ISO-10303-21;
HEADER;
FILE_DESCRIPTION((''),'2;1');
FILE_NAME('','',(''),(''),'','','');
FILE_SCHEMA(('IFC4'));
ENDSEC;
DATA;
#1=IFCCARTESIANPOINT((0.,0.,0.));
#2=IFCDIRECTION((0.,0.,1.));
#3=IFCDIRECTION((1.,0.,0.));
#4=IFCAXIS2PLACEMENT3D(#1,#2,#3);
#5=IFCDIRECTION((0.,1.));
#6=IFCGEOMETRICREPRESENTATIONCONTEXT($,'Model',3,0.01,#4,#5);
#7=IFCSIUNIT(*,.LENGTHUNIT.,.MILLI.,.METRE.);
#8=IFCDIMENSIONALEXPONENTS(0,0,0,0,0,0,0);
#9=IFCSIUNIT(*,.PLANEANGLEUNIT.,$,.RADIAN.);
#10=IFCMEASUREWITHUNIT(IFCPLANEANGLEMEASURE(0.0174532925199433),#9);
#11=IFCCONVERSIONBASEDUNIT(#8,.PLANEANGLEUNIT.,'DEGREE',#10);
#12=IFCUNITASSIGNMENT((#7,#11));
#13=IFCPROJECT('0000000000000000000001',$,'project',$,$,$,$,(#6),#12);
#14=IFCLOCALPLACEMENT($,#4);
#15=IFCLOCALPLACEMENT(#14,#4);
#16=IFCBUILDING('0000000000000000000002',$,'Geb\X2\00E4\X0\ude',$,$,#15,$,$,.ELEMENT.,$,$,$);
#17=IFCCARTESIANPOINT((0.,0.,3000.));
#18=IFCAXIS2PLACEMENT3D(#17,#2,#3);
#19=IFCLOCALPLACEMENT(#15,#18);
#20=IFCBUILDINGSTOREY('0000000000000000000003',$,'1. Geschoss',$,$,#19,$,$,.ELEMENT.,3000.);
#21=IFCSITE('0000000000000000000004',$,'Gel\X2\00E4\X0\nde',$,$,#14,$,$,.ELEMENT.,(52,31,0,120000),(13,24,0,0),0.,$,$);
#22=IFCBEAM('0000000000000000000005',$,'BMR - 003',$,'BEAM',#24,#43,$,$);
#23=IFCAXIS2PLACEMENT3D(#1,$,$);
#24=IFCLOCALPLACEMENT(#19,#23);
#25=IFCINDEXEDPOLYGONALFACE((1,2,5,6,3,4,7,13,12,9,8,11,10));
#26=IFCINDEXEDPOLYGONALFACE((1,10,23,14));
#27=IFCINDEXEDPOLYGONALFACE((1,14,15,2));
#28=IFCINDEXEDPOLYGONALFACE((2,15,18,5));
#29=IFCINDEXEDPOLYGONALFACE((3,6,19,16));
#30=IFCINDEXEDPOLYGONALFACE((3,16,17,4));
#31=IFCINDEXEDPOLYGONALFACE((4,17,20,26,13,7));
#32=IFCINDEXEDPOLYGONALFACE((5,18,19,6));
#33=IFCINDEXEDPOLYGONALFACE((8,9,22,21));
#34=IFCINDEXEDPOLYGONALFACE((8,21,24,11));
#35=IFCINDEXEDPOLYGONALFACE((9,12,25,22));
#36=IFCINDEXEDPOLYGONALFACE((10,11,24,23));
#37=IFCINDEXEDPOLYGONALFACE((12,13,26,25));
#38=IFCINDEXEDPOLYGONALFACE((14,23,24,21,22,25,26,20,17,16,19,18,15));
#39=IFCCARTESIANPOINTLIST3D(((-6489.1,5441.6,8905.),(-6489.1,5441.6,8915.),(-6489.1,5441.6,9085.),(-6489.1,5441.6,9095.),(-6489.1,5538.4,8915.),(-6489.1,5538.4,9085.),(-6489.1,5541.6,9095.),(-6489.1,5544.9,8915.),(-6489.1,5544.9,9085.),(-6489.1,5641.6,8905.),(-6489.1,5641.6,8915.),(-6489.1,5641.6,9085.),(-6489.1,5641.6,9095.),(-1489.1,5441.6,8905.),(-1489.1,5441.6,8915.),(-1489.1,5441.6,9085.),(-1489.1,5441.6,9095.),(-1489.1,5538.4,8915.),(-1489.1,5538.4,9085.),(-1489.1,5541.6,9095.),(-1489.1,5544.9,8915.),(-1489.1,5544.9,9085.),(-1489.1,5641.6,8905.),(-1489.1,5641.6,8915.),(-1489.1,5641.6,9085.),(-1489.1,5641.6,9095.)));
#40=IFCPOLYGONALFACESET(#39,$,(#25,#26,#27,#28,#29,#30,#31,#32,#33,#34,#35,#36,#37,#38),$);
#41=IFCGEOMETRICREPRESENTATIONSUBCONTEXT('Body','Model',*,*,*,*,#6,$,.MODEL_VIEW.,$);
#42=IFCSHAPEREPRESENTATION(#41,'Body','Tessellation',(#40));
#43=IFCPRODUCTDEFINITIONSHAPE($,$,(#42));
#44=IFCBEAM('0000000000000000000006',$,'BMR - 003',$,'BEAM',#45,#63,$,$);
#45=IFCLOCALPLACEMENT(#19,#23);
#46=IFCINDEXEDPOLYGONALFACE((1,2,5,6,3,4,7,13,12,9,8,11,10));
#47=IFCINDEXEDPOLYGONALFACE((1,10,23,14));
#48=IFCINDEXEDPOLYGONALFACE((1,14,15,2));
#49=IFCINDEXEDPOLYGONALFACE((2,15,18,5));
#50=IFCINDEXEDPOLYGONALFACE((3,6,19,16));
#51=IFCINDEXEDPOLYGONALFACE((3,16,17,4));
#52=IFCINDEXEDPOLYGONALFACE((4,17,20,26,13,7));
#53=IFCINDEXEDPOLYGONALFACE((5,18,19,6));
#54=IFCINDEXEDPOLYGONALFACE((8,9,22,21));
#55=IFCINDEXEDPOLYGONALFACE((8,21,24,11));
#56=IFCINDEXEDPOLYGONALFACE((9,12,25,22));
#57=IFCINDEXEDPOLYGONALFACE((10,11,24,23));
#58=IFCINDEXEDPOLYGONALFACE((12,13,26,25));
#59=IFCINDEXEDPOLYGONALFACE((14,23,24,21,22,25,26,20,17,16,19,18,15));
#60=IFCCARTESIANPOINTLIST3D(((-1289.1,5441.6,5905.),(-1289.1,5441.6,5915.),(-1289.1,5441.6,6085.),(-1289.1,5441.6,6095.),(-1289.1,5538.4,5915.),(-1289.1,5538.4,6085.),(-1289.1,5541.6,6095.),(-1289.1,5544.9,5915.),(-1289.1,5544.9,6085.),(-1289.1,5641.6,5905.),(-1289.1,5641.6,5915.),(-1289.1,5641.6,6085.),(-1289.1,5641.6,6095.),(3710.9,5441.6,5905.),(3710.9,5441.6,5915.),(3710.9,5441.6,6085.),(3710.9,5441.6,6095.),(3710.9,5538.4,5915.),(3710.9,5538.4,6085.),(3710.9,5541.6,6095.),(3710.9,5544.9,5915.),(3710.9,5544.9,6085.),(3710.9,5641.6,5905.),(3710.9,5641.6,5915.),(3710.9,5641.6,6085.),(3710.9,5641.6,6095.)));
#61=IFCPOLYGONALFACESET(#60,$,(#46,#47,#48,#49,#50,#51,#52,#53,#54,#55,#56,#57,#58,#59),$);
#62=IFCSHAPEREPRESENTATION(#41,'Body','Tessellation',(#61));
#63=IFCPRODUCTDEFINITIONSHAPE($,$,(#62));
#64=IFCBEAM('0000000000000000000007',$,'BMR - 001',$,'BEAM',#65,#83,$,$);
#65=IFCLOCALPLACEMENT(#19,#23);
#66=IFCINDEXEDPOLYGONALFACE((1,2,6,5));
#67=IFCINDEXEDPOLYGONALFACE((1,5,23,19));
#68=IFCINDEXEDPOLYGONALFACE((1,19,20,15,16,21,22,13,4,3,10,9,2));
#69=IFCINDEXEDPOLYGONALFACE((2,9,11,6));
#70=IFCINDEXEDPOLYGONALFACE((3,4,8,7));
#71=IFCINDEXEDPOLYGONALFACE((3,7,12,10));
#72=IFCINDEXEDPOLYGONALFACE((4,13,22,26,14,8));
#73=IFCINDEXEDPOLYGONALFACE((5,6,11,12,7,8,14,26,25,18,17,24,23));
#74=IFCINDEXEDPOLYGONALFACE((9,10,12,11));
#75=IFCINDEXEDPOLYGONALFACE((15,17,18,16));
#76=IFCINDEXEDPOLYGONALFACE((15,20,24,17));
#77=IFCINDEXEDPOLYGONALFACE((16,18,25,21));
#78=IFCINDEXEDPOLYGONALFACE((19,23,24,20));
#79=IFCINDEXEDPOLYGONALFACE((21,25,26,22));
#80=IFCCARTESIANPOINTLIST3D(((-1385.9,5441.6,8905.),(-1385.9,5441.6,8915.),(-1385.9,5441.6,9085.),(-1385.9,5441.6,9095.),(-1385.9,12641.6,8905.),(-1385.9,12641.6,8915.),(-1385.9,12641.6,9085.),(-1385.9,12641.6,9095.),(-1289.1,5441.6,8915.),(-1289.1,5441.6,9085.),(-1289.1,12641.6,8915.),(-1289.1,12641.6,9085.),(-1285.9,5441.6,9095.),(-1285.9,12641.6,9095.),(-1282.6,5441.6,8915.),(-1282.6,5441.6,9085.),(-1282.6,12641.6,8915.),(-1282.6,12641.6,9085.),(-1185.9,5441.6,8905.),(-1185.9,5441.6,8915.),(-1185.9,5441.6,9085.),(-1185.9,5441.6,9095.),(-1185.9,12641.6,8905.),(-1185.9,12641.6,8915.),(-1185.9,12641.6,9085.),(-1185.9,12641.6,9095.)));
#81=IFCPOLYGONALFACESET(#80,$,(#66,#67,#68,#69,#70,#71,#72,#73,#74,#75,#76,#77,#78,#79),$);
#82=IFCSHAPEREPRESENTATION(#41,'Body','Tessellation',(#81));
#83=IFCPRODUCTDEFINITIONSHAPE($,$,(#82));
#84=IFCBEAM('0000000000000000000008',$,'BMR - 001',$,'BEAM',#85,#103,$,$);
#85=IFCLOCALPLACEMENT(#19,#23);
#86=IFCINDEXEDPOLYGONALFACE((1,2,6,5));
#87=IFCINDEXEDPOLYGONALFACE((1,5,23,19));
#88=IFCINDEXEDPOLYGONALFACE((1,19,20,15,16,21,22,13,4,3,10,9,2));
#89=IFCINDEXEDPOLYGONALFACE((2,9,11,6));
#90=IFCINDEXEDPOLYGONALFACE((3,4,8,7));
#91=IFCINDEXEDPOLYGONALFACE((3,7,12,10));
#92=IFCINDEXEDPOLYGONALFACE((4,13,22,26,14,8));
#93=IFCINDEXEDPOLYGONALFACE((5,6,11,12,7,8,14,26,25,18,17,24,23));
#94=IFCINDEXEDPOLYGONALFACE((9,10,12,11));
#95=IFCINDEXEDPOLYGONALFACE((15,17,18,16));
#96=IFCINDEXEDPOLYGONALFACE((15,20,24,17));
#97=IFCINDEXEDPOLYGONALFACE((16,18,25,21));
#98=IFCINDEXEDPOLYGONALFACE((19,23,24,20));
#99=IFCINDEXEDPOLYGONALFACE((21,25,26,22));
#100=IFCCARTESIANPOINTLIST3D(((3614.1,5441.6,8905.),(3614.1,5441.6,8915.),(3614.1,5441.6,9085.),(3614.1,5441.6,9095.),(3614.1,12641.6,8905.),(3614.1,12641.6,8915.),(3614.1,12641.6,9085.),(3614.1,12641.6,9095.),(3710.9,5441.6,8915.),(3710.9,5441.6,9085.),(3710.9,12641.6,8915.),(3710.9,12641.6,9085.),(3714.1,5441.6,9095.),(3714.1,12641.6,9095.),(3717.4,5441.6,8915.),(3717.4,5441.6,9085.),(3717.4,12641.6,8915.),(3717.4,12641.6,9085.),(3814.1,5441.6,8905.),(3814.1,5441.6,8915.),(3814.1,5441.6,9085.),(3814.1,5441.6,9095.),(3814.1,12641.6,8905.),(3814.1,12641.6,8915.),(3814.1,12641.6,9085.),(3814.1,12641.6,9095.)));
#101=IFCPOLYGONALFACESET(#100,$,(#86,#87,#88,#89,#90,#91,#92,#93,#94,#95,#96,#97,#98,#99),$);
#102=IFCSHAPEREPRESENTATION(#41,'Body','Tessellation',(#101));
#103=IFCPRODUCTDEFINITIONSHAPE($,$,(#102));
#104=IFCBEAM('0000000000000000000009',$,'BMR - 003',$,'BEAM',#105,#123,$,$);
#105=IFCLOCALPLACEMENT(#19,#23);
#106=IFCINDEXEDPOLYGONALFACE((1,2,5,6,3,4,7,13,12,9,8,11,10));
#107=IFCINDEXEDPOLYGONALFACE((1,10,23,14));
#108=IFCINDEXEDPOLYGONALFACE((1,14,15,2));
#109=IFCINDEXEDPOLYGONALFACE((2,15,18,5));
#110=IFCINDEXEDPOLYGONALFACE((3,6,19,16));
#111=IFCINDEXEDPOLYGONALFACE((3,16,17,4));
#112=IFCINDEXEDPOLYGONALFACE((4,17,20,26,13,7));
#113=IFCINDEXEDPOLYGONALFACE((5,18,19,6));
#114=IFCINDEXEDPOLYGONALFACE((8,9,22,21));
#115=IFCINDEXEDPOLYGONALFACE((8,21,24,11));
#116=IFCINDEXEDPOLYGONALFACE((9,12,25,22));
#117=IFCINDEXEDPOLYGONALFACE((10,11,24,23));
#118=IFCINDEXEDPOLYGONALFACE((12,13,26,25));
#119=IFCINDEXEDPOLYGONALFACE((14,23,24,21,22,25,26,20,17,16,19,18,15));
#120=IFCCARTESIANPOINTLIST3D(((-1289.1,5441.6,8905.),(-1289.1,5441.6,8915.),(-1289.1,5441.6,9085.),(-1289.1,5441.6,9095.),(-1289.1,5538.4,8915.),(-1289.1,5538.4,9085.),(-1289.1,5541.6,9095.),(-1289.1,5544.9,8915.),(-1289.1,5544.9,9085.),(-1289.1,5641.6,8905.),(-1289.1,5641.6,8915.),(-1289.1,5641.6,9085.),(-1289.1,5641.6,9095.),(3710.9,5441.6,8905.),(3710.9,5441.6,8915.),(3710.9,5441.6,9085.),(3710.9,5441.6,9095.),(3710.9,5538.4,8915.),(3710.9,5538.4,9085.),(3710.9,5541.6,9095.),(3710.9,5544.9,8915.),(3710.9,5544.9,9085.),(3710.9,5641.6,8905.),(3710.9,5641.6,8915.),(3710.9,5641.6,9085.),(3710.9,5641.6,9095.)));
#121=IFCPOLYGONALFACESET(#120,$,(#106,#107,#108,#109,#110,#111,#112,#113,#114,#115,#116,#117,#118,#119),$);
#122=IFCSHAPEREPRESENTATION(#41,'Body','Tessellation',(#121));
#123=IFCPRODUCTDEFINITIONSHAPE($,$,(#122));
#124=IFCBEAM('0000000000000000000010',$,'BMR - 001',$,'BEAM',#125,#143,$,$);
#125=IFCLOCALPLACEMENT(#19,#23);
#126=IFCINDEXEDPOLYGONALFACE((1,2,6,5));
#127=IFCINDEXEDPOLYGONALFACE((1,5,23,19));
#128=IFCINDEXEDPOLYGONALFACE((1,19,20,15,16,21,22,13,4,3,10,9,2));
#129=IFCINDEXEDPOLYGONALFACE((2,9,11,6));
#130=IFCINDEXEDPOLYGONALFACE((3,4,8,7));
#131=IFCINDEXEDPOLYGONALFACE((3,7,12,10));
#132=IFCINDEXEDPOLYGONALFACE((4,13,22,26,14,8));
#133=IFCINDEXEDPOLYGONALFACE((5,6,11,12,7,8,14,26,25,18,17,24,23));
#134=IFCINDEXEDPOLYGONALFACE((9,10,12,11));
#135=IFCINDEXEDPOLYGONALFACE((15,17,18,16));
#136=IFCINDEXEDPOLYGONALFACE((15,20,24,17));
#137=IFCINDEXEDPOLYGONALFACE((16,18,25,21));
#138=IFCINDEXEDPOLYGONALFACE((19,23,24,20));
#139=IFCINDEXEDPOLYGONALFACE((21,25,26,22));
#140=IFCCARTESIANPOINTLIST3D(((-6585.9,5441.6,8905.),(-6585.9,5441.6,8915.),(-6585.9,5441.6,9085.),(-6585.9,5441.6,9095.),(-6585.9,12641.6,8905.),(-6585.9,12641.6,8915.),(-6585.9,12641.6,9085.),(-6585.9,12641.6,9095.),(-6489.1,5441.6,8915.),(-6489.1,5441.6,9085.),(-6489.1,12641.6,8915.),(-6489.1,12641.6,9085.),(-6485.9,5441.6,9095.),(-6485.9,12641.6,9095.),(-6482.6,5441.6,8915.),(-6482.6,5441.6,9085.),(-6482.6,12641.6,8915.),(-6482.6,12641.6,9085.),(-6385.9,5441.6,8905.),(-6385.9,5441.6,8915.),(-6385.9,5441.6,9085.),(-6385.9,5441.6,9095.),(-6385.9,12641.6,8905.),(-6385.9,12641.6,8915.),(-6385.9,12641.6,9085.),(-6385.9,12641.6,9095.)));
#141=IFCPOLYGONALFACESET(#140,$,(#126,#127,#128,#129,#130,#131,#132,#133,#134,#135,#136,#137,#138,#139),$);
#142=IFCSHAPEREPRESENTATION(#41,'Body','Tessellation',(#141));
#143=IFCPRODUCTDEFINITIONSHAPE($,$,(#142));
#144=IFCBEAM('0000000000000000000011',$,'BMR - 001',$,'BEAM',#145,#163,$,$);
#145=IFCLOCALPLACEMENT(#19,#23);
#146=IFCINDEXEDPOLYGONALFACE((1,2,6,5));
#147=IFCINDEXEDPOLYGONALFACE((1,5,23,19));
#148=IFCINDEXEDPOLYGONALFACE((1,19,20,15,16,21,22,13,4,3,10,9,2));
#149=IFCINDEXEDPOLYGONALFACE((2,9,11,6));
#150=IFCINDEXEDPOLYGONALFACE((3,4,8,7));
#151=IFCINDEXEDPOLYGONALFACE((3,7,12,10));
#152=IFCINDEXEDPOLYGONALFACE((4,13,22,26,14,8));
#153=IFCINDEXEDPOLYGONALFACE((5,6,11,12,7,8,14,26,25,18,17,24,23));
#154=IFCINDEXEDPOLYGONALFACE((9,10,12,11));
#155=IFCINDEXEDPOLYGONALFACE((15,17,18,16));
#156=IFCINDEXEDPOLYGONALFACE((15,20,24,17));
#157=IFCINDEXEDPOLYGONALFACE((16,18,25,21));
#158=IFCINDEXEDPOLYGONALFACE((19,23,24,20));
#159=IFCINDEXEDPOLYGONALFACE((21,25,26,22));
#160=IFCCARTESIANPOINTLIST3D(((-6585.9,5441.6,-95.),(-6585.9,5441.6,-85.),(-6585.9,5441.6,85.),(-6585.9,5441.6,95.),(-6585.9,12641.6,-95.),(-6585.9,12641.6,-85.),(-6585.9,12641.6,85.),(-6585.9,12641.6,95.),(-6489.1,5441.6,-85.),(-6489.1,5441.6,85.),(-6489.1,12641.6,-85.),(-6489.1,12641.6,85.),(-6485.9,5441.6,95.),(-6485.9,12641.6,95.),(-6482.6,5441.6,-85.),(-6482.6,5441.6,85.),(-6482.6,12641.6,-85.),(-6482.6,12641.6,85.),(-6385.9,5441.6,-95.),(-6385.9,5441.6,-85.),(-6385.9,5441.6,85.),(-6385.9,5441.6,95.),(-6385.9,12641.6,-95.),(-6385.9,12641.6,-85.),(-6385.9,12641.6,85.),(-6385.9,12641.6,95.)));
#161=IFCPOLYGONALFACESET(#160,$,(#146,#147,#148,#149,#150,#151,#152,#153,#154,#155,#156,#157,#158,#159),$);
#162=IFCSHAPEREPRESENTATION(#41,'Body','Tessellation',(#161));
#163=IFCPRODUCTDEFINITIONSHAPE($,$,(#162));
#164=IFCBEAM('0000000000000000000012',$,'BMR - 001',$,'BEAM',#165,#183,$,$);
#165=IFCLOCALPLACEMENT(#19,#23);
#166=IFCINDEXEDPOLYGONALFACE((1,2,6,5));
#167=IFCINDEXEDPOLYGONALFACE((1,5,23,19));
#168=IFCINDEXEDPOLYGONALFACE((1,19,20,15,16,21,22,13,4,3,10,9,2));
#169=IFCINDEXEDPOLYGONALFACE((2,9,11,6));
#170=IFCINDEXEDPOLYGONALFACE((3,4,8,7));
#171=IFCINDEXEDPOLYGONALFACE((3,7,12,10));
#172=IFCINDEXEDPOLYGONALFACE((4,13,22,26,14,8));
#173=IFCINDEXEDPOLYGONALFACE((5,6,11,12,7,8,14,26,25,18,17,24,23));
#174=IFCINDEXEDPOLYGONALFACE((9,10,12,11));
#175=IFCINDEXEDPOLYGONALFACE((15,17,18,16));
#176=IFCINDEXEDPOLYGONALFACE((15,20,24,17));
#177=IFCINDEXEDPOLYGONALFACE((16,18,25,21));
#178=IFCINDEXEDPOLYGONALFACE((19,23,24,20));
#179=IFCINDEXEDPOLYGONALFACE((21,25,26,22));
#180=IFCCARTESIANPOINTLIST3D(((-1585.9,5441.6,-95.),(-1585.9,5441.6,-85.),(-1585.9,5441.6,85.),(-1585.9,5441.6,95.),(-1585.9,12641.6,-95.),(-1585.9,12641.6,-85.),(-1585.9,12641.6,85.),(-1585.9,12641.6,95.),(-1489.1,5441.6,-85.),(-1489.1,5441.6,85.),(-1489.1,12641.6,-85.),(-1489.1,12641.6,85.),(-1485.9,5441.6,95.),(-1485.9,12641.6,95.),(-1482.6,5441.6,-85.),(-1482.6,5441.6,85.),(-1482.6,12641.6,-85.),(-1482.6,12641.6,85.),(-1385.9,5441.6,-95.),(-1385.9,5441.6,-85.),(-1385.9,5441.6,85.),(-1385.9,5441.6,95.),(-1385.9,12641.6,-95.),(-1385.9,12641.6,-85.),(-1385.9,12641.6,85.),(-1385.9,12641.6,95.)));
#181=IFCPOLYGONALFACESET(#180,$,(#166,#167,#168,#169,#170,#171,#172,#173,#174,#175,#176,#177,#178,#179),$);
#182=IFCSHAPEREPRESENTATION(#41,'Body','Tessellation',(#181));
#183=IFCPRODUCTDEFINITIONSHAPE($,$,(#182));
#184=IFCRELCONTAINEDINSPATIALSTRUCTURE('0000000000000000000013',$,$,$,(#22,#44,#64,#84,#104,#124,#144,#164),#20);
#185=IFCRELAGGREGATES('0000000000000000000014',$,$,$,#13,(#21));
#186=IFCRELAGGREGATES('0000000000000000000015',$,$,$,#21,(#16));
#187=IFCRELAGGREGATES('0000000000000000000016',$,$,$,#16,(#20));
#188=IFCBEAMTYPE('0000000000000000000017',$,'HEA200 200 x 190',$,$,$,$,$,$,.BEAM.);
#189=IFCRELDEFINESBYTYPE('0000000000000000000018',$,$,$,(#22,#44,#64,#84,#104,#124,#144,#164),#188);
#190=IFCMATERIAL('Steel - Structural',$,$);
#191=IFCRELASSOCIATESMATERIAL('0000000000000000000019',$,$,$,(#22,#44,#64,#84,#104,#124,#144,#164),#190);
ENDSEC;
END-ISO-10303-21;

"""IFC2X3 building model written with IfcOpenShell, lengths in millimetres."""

from ifc_helpers import new_model, entity, si_unit, converted_unit, direction, frame, origin_with_axes, place, context, subcontext, project, spatial, polyline, outline, extrude, material, type_object, element, save


model = new_model("IFC2X3")

# Units and contexts
model_context = context("Model", 3, precision=0.01, world=origin_with_axes(), true_north=direction((0.0, 1.0)))
body_context = subcontext(model_context, "Body", "Model", "MODEL_VIEW")
ifc_project = project(units=[si_unit("LENGTHUNIT", "METRE", prefix="MILLI"), converted_unit("PLANEANGLEUNIT", "DEGREE", entity("IfcPlaneAngleMeasure", 0.0174532925199433), si_unit("PLANEANGLEUNIT", "RADIAN"), dimensions=[0, 0, 0, 0, 0, 0, 0])], contexts=[model_context])

# Site, building, storey
site_placement = place(None, origin_with_axes())
site = spatial("IfcSite", under=ifc_project, at=site_placement, Name="Gelände", CompositionType="ELEMENT", RefLatitude=(52, 31, 0, 120000), RefLongitude=(13, 24, 0, 0), RefElevation=0.0)
building_placement = place(site_placement, origin_with_axes())
building = spatial("IfcBuilding", under=site, at=building_placement, Name="Gebäude", CompositionType="ELEMENT")
storey_placement = place(building_placement, frame((0.0, 0.0, 3000.0), z_axis=(0.0, 0.0, 1.0), x_axis=(1.0, 0.0, 0.0)))
storey = spatial("IfcBuildingStorey", under=building, at=storey_placement, Name="1. Geschoss", CompositionType="ELEMENT", Elevation=3000.0)

# Beams
ifc_material = material(Name="Steel - Structural")
beam_type = type_object("IfcBeamType", Name="HEA200 200 x 190", PredefinedType="BEAM")
for number, where, z_axis, x_axis, name in (
    (1, (-6489.1, 5541.6, 9000.0), (0.0, 0.0, 1.0), (0.0, -1.0, 0.0), "BMR - 003"),
    (2, (-1289.1, 5541.6, 6000.0), (0.0, 0.0, 1.0), (0.0, -1.0, 0.0), "BMR - 003"),
):
    element("IfcBeam", number, at=place(storey_placement, frame(where, z_axis=z_axis, x_axis=x_axis)), inside=storey, type_object=beam_type, material=ifc_material, Name=name, ObjectType="BEAM", context=body_context, shape_type="SweptSolid", body=[
        extrude(outline(polyline([(0.0, 95.0), (-100.0, 95.0), (-100.0, 85.0), (-3.2, 85.0), (-3.2, -85.0), (-100.0, -85.0), (-100.0, -95.0), (100.0, -95.0), (100.0, -85.0), (3.2, -85.0), (3.2, 85.0), (100.0, 85.0), (100.0, 95.0), (0.0, 95.0)])), frame((0.0, 5000.0, 0.0), z_axis=(0.0, -1.0, 0.0), x_axis=(1.0, 0.0, 0.0)), (0.0, 0.0, 1.0), 5000.0),
    ])
for number, where, z_axis, x_axis, name in (
    (3, (-1285.9, 5441.6, 9000.0), (0.0, 0.0, 1.0), (1.0, 0.0, 0.0), "BMR - 001"),
    (4, (3714.1, 5441.6, 9000.0), (0.0, 0.0, 1.0), (1.0, 0.0, 0.0), "BMR - 001"),
):
    element("IfcBeam", number, at=place(storey_placement, frame(where, z_axis=z_axis, x_axis=x_axis)), inside=storey, type_object=beam_type, material=ifc_material, Name=name, ObjectType="BEAM", context=body_context, shape_type="SweptSolid", body=[
        extrude(outline(polyline([(0.0, 95.0), (-100.0, 95.0), (-100.0, 85.0), (-3.2, 85.0), (-3.2, -85.0), (-100.0, -85.0), (-100.0, -95.0), (100.0, -95.0), (100.0, -85.0), (3.2, -85.0), (3.2, 85.0), (100.0, 85.0), (100.0, 95.0), (0.0, 95.0)])), frame((0.0, 7200.0, 0.0), z_axis=(0.0, -1.0, 0.0), x_axis=(1.0, 0.0, 0.0)), (0.0, 0.0, 1.0), 7200.0),
    ])
beam_1_placement = place(storey_placement, frame((-1289.1, 5541.6, 9000.0), z_axis=(0.0, 0.0, 1.0), x_axis=(0.0, -1.0, 0.0)))
element("IfcBeam", 5, at=beam_1_placement, inside=storey, type_object=beam_type, material=ifc_material, Name="BMR - 003", ObjectType="BEAM", context=body_context, shape_type="SweptSolid", body=[
    extrude(outline(polyline([(0.0, 95.0), (-100.0, 95.0), (-100.0, 85.0), (-3.2, 85.0), (-3.2, -85.0), (-100.0, -85.0), (-100.0, -95.0), (100.0, -95.0), (100.0, -85.0), (3.2, -85.0), (3.2, 85.0), (100.0, 85.0), (100.0, 95.0), (0.0, 95.0)])), frame((0.0, 5000.0, 0.0), z_axis=(0.0, -1.0, 0.0), x_axis=(1.0, 0.0, 0.0)), (0.0, 0.0, 1.0), 5000.0),
])
for number, where, z_axis, x_axis, name in (
    (6, (-6485.9, 5441.6, 9000.0), (0.0, 0.0, 1.0), (1.0, 0.0, 0.0), "BMR - 001"),
    (7, (-6485.9, 5441.6, 0.0), (0.0, 0.0, 1.0), (1.0, 0.0, 0.0), "BMR - 001"),
    (8, (-1485.9, 5441.6, 0.0), (0.0, 0.0, 1.0), (1.0, 0.0, 0.0), "BMR - 001"),
):
    element("IfcBeam", number, at=place(storey_placement, frame(where, z_axis=z_axis, x_axis=x_axis)), inside=storey, type_object=beam_type, material=ifc_material, Name=name, ObjectType="BEAM", context=body_context, shape_type="SweptSolid", body=[
        extrude(outline(polyline([(0.0, 95.0), (-100.0, 95.0), (-100.0, 85.0), (-3.2, 85.0), (-3.2, -85.0), (-100.0, -85.0), (-100.0, -95.0), (100.0, -95.0), (100.0, -85.0), (3.2, -85.0), (3.2, 85.0), (100.0, 85.0), (100.0, 95.0), (0.0, 95.0)])), frame((0.0, 7200.0, 0.0), z_axis=(0.0, -1.0, 0.0), x_axis=(1.0, 0.0, 0.0)), (0.0, 0.0, 1.0), 7200.0),
    ])

save(model, "model.ifc")
